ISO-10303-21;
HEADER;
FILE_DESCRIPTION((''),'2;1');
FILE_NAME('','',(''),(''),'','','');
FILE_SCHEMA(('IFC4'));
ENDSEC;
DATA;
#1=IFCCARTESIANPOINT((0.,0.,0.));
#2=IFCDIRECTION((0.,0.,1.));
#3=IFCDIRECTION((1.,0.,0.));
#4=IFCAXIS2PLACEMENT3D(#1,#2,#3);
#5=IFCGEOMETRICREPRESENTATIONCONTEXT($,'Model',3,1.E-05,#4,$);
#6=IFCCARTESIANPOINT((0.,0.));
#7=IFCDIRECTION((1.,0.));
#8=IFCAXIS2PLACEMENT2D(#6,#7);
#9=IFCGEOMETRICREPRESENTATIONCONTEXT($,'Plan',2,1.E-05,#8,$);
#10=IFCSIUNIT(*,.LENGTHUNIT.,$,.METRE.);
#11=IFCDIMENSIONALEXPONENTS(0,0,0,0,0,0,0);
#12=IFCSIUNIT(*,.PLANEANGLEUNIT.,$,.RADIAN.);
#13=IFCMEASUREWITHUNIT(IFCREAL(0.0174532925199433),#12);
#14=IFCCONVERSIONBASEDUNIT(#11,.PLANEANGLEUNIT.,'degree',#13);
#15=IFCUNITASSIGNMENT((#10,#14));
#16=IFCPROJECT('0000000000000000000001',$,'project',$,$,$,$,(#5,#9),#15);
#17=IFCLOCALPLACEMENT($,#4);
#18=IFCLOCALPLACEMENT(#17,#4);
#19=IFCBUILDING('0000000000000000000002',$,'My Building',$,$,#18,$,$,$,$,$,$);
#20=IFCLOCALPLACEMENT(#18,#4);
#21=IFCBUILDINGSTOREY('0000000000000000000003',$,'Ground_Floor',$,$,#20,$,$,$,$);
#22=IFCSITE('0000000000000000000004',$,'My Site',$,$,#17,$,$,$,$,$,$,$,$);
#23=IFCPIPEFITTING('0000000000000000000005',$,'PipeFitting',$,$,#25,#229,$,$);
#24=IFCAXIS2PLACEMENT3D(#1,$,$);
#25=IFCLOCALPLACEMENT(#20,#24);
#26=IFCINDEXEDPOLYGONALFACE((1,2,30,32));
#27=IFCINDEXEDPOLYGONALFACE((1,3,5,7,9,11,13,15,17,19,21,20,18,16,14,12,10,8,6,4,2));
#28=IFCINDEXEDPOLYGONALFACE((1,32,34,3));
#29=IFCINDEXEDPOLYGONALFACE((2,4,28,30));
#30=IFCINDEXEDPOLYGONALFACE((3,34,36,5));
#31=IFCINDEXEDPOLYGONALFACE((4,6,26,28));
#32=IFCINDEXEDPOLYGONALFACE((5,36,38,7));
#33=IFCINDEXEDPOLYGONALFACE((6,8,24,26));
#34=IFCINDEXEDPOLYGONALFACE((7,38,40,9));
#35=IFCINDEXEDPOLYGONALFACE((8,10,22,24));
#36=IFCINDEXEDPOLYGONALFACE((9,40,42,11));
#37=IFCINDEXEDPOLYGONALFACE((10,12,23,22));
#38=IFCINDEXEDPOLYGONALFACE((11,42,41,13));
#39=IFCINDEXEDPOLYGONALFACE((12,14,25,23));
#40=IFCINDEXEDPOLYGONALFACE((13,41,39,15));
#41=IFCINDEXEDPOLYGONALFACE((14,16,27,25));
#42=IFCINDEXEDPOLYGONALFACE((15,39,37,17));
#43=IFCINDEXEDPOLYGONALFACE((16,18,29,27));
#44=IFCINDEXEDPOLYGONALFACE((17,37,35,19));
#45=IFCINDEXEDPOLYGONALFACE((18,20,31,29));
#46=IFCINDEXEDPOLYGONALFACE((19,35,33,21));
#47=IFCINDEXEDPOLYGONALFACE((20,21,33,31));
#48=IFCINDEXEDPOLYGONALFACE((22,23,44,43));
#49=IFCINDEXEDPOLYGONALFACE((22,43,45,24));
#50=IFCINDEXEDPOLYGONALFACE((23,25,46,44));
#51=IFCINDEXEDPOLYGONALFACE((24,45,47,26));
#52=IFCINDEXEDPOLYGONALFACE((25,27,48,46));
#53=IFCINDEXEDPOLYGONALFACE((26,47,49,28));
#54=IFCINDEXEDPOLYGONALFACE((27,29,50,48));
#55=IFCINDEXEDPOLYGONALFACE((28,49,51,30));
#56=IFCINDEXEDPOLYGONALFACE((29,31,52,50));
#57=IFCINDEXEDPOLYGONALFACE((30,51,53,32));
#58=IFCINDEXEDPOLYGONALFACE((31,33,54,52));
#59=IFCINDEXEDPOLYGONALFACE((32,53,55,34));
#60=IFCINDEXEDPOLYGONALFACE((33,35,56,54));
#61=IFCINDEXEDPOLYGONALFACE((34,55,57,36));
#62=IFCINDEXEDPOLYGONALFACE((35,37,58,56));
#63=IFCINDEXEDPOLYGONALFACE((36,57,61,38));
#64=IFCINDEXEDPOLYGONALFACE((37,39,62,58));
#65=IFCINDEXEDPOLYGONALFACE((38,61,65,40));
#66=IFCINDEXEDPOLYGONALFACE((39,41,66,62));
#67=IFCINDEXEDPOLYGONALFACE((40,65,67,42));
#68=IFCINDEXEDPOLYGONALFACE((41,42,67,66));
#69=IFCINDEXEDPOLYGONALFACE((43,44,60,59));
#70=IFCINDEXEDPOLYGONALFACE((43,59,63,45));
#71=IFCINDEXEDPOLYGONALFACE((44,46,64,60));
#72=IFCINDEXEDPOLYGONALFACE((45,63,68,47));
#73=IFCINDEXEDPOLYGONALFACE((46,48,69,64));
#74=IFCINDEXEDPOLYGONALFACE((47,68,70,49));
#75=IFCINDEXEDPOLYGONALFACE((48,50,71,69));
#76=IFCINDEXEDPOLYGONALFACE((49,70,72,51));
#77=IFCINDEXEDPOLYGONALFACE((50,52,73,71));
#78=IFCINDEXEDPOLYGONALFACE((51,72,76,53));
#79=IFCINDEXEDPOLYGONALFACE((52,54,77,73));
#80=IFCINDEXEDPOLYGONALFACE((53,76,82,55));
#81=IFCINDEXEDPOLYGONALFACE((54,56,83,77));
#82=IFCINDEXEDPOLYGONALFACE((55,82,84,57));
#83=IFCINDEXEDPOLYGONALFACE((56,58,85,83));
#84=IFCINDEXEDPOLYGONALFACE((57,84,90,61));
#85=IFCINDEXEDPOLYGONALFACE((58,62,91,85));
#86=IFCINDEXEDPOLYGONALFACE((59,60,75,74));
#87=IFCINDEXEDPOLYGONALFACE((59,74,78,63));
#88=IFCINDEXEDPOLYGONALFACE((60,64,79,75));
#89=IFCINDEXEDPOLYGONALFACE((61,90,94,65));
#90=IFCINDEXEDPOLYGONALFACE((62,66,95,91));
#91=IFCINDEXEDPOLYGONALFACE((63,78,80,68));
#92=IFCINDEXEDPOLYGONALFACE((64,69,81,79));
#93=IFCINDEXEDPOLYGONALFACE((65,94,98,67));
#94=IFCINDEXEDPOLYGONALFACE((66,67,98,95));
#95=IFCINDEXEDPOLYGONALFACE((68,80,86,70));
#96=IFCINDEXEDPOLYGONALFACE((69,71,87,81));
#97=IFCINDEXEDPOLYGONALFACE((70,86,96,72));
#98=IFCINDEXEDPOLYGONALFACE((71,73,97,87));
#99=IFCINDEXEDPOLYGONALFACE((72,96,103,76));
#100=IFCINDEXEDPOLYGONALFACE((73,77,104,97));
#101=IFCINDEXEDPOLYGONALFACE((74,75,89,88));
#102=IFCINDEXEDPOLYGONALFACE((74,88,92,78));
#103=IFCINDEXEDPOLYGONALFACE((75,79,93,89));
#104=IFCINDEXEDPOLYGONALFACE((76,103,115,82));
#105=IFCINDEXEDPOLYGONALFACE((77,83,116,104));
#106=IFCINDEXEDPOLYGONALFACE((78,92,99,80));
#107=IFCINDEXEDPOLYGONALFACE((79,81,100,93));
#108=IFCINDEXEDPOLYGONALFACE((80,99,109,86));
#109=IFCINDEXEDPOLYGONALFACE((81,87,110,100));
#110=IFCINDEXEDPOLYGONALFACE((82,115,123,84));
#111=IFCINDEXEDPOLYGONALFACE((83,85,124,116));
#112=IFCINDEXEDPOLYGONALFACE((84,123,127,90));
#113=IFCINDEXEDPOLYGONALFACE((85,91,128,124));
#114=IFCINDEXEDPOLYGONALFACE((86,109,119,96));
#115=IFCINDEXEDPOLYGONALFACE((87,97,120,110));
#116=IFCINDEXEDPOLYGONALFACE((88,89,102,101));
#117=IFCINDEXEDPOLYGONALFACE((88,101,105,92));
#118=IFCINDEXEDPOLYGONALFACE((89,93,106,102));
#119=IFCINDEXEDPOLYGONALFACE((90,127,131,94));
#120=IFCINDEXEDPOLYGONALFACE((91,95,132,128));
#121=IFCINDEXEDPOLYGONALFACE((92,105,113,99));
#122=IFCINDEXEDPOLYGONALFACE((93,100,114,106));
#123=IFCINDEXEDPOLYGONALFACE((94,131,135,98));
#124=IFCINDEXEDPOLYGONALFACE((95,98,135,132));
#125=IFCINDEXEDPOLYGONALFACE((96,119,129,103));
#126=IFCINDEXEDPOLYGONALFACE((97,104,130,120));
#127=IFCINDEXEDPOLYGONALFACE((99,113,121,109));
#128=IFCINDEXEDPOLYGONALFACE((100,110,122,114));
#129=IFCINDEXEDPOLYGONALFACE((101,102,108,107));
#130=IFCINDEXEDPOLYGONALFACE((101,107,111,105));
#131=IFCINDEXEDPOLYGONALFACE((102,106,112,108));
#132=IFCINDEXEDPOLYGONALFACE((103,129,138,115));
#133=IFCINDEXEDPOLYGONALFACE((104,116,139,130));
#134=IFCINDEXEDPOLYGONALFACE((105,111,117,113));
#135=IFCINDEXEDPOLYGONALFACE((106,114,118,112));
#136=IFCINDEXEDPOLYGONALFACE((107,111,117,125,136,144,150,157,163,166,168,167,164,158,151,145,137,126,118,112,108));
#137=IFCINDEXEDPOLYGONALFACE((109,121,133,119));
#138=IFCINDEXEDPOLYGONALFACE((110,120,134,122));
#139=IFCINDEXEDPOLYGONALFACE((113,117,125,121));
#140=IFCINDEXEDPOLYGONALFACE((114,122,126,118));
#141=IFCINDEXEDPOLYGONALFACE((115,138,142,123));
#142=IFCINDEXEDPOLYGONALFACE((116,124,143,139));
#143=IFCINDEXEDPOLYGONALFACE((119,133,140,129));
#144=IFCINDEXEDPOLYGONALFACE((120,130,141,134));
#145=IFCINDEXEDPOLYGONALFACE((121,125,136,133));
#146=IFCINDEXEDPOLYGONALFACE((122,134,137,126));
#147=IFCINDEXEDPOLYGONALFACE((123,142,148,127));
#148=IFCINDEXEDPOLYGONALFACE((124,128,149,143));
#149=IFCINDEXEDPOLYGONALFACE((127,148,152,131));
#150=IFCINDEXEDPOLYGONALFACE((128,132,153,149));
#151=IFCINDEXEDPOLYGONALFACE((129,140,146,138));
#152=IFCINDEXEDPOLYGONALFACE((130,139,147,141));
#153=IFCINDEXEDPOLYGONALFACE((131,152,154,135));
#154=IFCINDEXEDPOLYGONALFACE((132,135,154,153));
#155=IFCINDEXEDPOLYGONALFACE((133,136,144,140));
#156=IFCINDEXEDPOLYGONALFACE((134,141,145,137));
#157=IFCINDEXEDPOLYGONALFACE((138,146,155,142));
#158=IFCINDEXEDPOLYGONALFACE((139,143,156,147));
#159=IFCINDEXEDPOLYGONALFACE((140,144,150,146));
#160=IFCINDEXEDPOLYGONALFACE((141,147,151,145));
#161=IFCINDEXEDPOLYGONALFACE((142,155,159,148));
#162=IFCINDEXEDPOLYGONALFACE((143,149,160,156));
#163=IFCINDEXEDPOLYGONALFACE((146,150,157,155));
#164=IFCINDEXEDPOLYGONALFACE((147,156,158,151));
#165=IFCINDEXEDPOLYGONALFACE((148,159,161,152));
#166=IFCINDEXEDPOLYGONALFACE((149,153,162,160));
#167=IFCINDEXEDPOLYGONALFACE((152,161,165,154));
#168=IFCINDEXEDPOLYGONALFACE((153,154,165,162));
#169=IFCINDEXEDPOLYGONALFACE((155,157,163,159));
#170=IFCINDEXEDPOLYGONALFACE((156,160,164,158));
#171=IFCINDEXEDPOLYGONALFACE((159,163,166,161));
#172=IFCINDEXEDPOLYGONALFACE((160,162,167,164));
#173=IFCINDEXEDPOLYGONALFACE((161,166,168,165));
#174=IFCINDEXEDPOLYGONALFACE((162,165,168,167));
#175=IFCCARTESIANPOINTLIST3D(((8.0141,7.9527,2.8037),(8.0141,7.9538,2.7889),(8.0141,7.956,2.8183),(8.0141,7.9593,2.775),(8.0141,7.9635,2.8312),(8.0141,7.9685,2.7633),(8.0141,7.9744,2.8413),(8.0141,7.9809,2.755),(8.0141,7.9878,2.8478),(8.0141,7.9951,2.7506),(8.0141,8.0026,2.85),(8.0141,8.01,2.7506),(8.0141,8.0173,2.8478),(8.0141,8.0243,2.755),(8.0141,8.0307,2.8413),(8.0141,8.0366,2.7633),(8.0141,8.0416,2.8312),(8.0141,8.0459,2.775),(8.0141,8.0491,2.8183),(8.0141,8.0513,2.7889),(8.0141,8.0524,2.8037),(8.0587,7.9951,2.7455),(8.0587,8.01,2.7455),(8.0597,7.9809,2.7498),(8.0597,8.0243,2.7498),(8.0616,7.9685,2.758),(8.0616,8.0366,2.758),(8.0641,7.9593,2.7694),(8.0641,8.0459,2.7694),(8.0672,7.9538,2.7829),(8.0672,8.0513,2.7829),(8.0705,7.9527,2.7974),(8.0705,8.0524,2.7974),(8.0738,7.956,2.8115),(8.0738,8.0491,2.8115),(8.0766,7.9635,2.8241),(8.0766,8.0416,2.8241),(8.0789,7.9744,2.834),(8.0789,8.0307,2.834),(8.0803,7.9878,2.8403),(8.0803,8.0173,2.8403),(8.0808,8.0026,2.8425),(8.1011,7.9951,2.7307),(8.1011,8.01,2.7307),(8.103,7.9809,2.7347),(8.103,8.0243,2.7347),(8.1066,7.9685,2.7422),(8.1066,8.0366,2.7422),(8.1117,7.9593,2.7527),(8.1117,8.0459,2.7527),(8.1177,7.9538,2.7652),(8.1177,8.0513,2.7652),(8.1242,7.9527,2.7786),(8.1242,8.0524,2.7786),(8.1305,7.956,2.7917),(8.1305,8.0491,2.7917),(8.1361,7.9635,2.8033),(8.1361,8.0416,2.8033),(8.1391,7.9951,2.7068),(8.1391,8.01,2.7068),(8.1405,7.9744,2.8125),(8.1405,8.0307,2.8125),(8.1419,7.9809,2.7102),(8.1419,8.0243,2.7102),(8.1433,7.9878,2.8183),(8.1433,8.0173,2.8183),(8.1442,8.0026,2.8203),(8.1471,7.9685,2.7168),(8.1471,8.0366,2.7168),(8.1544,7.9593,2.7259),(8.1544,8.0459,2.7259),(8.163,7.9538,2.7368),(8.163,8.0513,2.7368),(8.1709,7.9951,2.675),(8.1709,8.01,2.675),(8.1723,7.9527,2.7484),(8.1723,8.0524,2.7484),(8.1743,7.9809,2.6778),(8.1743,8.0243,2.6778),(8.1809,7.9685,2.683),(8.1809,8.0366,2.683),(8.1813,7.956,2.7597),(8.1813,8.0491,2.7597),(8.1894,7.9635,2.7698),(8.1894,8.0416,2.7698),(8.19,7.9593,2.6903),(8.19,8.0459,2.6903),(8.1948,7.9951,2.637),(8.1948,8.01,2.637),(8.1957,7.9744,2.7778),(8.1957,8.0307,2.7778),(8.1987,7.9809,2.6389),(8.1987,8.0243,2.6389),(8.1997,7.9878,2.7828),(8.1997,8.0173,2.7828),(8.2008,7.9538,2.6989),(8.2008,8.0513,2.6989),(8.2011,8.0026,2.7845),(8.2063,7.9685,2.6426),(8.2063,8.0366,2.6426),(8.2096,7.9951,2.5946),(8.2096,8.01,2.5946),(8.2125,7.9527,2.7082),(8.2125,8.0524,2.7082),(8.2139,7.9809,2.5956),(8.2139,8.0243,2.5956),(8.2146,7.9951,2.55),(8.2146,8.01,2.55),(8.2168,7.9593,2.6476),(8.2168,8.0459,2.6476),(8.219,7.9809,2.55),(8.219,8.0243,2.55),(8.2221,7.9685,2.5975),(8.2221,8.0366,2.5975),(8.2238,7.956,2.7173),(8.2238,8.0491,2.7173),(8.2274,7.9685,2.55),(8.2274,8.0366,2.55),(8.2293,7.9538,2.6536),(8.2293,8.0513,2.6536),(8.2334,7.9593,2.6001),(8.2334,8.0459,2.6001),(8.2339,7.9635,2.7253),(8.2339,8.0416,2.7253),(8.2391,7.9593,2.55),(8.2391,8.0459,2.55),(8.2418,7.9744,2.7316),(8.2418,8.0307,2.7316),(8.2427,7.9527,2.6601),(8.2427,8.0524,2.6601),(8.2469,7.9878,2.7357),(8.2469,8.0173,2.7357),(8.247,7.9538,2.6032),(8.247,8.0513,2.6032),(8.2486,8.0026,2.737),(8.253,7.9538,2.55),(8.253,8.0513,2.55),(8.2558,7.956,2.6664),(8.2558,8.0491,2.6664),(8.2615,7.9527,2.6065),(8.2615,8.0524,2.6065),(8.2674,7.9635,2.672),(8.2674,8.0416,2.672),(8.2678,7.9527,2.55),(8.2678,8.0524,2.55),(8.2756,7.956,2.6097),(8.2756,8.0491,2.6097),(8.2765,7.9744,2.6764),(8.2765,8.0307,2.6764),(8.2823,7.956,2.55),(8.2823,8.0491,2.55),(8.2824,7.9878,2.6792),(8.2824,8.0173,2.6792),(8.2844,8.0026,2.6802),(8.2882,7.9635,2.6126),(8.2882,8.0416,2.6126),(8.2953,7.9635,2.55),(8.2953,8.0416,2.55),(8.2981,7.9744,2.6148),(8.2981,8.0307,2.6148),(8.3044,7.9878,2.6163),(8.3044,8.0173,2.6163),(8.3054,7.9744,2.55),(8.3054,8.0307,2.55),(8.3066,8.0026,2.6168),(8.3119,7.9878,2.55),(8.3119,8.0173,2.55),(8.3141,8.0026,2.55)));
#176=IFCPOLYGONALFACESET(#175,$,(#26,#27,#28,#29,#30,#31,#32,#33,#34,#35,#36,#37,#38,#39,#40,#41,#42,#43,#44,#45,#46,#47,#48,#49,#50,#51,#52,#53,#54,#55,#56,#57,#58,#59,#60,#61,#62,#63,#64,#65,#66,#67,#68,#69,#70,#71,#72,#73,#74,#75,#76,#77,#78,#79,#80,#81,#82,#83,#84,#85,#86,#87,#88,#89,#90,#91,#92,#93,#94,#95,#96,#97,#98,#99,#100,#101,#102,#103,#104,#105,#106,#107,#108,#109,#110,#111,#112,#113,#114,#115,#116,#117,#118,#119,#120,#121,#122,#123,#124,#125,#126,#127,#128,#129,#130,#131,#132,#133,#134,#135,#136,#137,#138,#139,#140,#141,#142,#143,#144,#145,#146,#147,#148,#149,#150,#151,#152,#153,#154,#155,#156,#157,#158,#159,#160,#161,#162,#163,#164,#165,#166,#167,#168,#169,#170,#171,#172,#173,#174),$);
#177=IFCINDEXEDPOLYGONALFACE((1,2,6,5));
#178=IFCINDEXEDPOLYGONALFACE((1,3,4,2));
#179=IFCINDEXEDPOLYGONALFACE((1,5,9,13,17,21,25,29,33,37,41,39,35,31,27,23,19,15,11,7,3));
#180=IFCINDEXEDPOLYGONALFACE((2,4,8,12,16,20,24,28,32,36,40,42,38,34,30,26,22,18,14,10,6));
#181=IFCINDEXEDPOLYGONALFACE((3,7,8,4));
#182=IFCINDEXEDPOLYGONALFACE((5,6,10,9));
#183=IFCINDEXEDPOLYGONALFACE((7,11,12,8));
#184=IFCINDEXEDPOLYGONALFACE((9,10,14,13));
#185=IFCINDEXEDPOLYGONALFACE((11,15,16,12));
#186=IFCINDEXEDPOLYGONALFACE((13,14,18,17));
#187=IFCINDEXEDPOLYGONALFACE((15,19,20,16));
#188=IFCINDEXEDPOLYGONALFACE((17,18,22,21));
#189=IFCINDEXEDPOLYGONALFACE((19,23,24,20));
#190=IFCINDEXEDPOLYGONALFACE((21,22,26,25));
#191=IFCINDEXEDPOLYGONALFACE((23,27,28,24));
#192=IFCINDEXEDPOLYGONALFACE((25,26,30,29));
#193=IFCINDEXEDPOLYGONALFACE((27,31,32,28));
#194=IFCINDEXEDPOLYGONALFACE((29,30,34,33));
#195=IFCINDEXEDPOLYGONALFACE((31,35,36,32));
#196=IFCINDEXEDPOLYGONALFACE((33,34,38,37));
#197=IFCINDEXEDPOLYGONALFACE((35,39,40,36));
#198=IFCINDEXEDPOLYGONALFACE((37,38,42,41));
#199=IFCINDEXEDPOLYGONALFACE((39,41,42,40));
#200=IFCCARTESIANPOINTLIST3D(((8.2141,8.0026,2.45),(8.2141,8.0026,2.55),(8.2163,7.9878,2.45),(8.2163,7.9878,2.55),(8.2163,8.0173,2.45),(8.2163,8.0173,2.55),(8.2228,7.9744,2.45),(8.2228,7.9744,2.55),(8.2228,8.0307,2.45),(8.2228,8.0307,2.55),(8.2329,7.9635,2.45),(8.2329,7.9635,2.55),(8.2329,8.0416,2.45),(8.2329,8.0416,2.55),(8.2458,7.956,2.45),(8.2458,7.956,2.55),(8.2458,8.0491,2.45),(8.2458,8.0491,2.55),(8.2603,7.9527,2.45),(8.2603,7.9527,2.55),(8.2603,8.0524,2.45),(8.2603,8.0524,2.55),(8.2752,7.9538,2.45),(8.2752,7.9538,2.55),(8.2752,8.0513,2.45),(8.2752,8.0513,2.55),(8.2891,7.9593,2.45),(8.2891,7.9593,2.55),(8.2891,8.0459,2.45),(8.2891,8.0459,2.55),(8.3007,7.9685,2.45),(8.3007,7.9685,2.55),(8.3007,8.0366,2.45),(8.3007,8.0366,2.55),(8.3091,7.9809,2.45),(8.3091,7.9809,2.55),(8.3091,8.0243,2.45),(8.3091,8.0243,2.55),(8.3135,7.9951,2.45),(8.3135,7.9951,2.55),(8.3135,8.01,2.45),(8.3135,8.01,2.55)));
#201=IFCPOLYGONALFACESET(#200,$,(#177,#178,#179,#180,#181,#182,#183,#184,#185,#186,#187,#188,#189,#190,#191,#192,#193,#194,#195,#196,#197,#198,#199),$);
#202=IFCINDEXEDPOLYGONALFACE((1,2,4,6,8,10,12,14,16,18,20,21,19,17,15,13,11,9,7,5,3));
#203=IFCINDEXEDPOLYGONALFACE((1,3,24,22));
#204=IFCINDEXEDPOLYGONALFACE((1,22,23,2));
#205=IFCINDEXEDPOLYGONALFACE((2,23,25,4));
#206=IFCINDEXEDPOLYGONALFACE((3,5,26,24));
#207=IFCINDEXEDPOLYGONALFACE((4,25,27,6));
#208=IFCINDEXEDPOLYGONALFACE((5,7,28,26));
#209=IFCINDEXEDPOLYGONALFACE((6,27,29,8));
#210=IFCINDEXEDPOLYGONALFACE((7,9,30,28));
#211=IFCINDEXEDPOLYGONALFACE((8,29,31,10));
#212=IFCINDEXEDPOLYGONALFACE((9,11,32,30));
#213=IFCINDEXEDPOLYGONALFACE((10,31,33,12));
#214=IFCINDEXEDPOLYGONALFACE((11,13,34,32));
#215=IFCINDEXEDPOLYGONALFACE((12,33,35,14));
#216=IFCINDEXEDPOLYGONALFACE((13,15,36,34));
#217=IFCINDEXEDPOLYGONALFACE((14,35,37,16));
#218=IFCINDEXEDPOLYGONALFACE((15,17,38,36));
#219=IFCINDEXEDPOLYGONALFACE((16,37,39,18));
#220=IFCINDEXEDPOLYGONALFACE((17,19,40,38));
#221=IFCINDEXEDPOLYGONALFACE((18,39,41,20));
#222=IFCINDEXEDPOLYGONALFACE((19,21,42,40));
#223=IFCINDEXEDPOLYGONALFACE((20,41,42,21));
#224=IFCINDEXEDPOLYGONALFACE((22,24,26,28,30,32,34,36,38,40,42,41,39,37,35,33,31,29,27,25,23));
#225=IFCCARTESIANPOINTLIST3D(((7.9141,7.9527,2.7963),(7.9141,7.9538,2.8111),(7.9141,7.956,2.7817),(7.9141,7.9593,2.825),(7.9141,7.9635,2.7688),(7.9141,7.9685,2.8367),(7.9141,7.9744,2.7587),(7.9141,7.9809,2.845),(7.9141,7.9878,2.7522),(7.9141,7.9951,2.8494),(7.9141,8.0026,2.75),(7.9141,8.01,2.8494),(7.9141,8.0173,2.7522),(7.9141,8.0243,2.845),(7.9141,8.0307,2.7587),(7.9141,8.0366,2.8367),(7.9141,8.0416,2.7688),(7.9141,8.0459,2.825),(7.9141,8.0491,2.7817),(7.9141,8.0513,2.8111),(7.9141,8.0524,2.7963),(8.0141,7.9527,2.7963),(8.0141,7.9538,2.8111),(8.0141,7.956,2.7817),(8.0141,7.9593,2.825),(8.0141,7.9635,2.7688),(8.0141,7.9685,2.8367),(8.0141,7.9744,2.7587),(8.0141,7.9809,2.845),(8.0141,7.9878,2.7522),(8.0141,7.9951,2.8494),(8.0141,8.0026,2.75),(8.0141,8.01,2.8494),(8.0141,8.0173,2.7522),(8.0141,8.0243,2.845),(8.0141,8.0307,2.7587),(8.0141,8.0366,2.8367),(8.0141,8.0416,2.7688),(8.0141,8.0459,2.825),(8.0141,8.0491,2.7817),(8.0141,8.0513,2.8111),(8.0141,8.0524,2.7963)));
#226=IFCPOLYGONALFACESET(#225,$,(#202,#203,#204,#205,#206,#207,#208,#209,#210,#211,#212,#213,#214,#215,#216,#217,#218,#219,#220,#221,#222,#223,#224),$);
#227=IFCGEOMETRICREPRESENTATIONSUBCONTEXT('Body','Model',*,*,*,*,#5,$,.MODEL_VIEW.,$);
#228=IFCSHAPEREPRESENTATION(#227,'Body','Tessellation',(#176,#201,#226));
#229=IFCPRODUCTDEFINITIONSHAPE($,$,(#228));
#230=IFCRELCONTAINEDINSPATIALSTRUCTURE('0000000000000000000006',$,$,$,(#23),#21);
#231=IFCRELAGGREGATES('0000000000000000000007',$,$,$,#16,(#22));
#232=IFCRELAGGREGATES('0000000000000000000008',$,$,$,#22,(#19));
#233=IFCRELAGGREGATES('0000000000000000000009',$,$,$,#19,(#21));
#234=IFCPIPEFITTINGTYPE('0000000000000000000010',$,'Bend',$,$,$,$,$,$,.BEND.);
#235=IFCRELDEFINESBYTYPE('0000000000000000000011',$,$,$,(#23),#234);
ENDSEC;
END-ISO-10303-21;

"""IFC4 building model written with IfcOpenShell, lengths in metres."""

from ifc_helpers import new_model, entity, si_unit, converted_unit, frame, origin_with_axes, origin_2d_with_axis, place, context, subcontext, project, spatial, circle, extrude, source, transform, mapped, type_object, type_shapes, element, save


model = new_model("IFC4")

# Units and contexts
model_context = context("Model", 3, precision=1e-05, world=origin_with_axes())
plan_context = context("Plan", 2, precision=1e-05, world=origin_2d_with_axis())
body_context = subcontext(model_context, "Body", "Model", "MODEL_VIEW")
ifc_project = project(units=[si_unit("LENGTHUNIT", "METRE"), converted_unit("PLANEANGLEUNIT", "degree", entity("IfcReal", 0.0174532925199433), si_unit("PLANEANGLEUNIT", "RADIAN"), dimensions=[0, 0, 0, 0, 0, 0, 0])], contexts=[model_context, plan_context])

# Site, building, storey
site_placement = place(None, origin_with_axes())
site = spatial("IfcSite", under=ifc_project, at=site_placement, Name="My Site")
building_placement = place(site_placement, origin_with_axes())
building = spatial("IfcBuilding", under=site, at=building_placement, Name="My Building")
storey_placement = place(building_placement, origin_with_axes())
storey = spatial("IfcBuildingStorey", under=building, at=storey_placement, Name="Ground_Floor")

# Pipe fitting
pipe_fitting_type = type_object("IfcPipeFittingType", Name="Bend", PredefinedType="BEND")
shared_shape = source(origin_with_axes(), body_context, "Body", "SolidModel", [
    entity("IfcSweptDiskSolid", entity("IfcIndexedPolyCurve", entity("IfcCartesianPointList3D", [[0.0, 0.0, -0.1], [0.0732, 0.0, -0.2768], [0.25, 0.0, -0.35]]), [entity("IfcArcIndex", [1, 2, 3])]), 0.05),
    extrude(circle(Radius=0.05), origin_with_axes(), (0.0, 0.0, -1.0), 0.1),
    extrude(circle(Radius=0.05), frame((0.25, 0.0, -0.35), z_axis=(1.0, 0.0, 0.0), x_axis=(0.0, 0.0, 1.0)), (0.0, 0.0, 1.0), 0.1),
])
type_shapes(pipe_fitting_type, [shared_shape])
for number, where, z_axis, x_axis, name in (
    (1, (8.2641, 8.0026, 2.45), (0.0, 0.0, -1.0), (-1.0, 0.0, 0.0), "PipeFitting"),
):
    element("IfcPipeFitting", number, at=place(storey_placement, frame(where, z_axis=z_axis, x_axis=x_axis)), inside=storey, type_object=pipe_fitting_type, Name=name, context=body_context, shape_type="MappedRepresentation", body=[
        mapped(shared_shape, transform((0.0, 0.0, 0.0), x_axis=(1.0, 0.0, 0.0), y_axis=(0.0, 1.0, 0.0), z_axis=(0.0, 0.0, 1.0), scale=1.0)),
    ])

save(model, "model.ifc")
